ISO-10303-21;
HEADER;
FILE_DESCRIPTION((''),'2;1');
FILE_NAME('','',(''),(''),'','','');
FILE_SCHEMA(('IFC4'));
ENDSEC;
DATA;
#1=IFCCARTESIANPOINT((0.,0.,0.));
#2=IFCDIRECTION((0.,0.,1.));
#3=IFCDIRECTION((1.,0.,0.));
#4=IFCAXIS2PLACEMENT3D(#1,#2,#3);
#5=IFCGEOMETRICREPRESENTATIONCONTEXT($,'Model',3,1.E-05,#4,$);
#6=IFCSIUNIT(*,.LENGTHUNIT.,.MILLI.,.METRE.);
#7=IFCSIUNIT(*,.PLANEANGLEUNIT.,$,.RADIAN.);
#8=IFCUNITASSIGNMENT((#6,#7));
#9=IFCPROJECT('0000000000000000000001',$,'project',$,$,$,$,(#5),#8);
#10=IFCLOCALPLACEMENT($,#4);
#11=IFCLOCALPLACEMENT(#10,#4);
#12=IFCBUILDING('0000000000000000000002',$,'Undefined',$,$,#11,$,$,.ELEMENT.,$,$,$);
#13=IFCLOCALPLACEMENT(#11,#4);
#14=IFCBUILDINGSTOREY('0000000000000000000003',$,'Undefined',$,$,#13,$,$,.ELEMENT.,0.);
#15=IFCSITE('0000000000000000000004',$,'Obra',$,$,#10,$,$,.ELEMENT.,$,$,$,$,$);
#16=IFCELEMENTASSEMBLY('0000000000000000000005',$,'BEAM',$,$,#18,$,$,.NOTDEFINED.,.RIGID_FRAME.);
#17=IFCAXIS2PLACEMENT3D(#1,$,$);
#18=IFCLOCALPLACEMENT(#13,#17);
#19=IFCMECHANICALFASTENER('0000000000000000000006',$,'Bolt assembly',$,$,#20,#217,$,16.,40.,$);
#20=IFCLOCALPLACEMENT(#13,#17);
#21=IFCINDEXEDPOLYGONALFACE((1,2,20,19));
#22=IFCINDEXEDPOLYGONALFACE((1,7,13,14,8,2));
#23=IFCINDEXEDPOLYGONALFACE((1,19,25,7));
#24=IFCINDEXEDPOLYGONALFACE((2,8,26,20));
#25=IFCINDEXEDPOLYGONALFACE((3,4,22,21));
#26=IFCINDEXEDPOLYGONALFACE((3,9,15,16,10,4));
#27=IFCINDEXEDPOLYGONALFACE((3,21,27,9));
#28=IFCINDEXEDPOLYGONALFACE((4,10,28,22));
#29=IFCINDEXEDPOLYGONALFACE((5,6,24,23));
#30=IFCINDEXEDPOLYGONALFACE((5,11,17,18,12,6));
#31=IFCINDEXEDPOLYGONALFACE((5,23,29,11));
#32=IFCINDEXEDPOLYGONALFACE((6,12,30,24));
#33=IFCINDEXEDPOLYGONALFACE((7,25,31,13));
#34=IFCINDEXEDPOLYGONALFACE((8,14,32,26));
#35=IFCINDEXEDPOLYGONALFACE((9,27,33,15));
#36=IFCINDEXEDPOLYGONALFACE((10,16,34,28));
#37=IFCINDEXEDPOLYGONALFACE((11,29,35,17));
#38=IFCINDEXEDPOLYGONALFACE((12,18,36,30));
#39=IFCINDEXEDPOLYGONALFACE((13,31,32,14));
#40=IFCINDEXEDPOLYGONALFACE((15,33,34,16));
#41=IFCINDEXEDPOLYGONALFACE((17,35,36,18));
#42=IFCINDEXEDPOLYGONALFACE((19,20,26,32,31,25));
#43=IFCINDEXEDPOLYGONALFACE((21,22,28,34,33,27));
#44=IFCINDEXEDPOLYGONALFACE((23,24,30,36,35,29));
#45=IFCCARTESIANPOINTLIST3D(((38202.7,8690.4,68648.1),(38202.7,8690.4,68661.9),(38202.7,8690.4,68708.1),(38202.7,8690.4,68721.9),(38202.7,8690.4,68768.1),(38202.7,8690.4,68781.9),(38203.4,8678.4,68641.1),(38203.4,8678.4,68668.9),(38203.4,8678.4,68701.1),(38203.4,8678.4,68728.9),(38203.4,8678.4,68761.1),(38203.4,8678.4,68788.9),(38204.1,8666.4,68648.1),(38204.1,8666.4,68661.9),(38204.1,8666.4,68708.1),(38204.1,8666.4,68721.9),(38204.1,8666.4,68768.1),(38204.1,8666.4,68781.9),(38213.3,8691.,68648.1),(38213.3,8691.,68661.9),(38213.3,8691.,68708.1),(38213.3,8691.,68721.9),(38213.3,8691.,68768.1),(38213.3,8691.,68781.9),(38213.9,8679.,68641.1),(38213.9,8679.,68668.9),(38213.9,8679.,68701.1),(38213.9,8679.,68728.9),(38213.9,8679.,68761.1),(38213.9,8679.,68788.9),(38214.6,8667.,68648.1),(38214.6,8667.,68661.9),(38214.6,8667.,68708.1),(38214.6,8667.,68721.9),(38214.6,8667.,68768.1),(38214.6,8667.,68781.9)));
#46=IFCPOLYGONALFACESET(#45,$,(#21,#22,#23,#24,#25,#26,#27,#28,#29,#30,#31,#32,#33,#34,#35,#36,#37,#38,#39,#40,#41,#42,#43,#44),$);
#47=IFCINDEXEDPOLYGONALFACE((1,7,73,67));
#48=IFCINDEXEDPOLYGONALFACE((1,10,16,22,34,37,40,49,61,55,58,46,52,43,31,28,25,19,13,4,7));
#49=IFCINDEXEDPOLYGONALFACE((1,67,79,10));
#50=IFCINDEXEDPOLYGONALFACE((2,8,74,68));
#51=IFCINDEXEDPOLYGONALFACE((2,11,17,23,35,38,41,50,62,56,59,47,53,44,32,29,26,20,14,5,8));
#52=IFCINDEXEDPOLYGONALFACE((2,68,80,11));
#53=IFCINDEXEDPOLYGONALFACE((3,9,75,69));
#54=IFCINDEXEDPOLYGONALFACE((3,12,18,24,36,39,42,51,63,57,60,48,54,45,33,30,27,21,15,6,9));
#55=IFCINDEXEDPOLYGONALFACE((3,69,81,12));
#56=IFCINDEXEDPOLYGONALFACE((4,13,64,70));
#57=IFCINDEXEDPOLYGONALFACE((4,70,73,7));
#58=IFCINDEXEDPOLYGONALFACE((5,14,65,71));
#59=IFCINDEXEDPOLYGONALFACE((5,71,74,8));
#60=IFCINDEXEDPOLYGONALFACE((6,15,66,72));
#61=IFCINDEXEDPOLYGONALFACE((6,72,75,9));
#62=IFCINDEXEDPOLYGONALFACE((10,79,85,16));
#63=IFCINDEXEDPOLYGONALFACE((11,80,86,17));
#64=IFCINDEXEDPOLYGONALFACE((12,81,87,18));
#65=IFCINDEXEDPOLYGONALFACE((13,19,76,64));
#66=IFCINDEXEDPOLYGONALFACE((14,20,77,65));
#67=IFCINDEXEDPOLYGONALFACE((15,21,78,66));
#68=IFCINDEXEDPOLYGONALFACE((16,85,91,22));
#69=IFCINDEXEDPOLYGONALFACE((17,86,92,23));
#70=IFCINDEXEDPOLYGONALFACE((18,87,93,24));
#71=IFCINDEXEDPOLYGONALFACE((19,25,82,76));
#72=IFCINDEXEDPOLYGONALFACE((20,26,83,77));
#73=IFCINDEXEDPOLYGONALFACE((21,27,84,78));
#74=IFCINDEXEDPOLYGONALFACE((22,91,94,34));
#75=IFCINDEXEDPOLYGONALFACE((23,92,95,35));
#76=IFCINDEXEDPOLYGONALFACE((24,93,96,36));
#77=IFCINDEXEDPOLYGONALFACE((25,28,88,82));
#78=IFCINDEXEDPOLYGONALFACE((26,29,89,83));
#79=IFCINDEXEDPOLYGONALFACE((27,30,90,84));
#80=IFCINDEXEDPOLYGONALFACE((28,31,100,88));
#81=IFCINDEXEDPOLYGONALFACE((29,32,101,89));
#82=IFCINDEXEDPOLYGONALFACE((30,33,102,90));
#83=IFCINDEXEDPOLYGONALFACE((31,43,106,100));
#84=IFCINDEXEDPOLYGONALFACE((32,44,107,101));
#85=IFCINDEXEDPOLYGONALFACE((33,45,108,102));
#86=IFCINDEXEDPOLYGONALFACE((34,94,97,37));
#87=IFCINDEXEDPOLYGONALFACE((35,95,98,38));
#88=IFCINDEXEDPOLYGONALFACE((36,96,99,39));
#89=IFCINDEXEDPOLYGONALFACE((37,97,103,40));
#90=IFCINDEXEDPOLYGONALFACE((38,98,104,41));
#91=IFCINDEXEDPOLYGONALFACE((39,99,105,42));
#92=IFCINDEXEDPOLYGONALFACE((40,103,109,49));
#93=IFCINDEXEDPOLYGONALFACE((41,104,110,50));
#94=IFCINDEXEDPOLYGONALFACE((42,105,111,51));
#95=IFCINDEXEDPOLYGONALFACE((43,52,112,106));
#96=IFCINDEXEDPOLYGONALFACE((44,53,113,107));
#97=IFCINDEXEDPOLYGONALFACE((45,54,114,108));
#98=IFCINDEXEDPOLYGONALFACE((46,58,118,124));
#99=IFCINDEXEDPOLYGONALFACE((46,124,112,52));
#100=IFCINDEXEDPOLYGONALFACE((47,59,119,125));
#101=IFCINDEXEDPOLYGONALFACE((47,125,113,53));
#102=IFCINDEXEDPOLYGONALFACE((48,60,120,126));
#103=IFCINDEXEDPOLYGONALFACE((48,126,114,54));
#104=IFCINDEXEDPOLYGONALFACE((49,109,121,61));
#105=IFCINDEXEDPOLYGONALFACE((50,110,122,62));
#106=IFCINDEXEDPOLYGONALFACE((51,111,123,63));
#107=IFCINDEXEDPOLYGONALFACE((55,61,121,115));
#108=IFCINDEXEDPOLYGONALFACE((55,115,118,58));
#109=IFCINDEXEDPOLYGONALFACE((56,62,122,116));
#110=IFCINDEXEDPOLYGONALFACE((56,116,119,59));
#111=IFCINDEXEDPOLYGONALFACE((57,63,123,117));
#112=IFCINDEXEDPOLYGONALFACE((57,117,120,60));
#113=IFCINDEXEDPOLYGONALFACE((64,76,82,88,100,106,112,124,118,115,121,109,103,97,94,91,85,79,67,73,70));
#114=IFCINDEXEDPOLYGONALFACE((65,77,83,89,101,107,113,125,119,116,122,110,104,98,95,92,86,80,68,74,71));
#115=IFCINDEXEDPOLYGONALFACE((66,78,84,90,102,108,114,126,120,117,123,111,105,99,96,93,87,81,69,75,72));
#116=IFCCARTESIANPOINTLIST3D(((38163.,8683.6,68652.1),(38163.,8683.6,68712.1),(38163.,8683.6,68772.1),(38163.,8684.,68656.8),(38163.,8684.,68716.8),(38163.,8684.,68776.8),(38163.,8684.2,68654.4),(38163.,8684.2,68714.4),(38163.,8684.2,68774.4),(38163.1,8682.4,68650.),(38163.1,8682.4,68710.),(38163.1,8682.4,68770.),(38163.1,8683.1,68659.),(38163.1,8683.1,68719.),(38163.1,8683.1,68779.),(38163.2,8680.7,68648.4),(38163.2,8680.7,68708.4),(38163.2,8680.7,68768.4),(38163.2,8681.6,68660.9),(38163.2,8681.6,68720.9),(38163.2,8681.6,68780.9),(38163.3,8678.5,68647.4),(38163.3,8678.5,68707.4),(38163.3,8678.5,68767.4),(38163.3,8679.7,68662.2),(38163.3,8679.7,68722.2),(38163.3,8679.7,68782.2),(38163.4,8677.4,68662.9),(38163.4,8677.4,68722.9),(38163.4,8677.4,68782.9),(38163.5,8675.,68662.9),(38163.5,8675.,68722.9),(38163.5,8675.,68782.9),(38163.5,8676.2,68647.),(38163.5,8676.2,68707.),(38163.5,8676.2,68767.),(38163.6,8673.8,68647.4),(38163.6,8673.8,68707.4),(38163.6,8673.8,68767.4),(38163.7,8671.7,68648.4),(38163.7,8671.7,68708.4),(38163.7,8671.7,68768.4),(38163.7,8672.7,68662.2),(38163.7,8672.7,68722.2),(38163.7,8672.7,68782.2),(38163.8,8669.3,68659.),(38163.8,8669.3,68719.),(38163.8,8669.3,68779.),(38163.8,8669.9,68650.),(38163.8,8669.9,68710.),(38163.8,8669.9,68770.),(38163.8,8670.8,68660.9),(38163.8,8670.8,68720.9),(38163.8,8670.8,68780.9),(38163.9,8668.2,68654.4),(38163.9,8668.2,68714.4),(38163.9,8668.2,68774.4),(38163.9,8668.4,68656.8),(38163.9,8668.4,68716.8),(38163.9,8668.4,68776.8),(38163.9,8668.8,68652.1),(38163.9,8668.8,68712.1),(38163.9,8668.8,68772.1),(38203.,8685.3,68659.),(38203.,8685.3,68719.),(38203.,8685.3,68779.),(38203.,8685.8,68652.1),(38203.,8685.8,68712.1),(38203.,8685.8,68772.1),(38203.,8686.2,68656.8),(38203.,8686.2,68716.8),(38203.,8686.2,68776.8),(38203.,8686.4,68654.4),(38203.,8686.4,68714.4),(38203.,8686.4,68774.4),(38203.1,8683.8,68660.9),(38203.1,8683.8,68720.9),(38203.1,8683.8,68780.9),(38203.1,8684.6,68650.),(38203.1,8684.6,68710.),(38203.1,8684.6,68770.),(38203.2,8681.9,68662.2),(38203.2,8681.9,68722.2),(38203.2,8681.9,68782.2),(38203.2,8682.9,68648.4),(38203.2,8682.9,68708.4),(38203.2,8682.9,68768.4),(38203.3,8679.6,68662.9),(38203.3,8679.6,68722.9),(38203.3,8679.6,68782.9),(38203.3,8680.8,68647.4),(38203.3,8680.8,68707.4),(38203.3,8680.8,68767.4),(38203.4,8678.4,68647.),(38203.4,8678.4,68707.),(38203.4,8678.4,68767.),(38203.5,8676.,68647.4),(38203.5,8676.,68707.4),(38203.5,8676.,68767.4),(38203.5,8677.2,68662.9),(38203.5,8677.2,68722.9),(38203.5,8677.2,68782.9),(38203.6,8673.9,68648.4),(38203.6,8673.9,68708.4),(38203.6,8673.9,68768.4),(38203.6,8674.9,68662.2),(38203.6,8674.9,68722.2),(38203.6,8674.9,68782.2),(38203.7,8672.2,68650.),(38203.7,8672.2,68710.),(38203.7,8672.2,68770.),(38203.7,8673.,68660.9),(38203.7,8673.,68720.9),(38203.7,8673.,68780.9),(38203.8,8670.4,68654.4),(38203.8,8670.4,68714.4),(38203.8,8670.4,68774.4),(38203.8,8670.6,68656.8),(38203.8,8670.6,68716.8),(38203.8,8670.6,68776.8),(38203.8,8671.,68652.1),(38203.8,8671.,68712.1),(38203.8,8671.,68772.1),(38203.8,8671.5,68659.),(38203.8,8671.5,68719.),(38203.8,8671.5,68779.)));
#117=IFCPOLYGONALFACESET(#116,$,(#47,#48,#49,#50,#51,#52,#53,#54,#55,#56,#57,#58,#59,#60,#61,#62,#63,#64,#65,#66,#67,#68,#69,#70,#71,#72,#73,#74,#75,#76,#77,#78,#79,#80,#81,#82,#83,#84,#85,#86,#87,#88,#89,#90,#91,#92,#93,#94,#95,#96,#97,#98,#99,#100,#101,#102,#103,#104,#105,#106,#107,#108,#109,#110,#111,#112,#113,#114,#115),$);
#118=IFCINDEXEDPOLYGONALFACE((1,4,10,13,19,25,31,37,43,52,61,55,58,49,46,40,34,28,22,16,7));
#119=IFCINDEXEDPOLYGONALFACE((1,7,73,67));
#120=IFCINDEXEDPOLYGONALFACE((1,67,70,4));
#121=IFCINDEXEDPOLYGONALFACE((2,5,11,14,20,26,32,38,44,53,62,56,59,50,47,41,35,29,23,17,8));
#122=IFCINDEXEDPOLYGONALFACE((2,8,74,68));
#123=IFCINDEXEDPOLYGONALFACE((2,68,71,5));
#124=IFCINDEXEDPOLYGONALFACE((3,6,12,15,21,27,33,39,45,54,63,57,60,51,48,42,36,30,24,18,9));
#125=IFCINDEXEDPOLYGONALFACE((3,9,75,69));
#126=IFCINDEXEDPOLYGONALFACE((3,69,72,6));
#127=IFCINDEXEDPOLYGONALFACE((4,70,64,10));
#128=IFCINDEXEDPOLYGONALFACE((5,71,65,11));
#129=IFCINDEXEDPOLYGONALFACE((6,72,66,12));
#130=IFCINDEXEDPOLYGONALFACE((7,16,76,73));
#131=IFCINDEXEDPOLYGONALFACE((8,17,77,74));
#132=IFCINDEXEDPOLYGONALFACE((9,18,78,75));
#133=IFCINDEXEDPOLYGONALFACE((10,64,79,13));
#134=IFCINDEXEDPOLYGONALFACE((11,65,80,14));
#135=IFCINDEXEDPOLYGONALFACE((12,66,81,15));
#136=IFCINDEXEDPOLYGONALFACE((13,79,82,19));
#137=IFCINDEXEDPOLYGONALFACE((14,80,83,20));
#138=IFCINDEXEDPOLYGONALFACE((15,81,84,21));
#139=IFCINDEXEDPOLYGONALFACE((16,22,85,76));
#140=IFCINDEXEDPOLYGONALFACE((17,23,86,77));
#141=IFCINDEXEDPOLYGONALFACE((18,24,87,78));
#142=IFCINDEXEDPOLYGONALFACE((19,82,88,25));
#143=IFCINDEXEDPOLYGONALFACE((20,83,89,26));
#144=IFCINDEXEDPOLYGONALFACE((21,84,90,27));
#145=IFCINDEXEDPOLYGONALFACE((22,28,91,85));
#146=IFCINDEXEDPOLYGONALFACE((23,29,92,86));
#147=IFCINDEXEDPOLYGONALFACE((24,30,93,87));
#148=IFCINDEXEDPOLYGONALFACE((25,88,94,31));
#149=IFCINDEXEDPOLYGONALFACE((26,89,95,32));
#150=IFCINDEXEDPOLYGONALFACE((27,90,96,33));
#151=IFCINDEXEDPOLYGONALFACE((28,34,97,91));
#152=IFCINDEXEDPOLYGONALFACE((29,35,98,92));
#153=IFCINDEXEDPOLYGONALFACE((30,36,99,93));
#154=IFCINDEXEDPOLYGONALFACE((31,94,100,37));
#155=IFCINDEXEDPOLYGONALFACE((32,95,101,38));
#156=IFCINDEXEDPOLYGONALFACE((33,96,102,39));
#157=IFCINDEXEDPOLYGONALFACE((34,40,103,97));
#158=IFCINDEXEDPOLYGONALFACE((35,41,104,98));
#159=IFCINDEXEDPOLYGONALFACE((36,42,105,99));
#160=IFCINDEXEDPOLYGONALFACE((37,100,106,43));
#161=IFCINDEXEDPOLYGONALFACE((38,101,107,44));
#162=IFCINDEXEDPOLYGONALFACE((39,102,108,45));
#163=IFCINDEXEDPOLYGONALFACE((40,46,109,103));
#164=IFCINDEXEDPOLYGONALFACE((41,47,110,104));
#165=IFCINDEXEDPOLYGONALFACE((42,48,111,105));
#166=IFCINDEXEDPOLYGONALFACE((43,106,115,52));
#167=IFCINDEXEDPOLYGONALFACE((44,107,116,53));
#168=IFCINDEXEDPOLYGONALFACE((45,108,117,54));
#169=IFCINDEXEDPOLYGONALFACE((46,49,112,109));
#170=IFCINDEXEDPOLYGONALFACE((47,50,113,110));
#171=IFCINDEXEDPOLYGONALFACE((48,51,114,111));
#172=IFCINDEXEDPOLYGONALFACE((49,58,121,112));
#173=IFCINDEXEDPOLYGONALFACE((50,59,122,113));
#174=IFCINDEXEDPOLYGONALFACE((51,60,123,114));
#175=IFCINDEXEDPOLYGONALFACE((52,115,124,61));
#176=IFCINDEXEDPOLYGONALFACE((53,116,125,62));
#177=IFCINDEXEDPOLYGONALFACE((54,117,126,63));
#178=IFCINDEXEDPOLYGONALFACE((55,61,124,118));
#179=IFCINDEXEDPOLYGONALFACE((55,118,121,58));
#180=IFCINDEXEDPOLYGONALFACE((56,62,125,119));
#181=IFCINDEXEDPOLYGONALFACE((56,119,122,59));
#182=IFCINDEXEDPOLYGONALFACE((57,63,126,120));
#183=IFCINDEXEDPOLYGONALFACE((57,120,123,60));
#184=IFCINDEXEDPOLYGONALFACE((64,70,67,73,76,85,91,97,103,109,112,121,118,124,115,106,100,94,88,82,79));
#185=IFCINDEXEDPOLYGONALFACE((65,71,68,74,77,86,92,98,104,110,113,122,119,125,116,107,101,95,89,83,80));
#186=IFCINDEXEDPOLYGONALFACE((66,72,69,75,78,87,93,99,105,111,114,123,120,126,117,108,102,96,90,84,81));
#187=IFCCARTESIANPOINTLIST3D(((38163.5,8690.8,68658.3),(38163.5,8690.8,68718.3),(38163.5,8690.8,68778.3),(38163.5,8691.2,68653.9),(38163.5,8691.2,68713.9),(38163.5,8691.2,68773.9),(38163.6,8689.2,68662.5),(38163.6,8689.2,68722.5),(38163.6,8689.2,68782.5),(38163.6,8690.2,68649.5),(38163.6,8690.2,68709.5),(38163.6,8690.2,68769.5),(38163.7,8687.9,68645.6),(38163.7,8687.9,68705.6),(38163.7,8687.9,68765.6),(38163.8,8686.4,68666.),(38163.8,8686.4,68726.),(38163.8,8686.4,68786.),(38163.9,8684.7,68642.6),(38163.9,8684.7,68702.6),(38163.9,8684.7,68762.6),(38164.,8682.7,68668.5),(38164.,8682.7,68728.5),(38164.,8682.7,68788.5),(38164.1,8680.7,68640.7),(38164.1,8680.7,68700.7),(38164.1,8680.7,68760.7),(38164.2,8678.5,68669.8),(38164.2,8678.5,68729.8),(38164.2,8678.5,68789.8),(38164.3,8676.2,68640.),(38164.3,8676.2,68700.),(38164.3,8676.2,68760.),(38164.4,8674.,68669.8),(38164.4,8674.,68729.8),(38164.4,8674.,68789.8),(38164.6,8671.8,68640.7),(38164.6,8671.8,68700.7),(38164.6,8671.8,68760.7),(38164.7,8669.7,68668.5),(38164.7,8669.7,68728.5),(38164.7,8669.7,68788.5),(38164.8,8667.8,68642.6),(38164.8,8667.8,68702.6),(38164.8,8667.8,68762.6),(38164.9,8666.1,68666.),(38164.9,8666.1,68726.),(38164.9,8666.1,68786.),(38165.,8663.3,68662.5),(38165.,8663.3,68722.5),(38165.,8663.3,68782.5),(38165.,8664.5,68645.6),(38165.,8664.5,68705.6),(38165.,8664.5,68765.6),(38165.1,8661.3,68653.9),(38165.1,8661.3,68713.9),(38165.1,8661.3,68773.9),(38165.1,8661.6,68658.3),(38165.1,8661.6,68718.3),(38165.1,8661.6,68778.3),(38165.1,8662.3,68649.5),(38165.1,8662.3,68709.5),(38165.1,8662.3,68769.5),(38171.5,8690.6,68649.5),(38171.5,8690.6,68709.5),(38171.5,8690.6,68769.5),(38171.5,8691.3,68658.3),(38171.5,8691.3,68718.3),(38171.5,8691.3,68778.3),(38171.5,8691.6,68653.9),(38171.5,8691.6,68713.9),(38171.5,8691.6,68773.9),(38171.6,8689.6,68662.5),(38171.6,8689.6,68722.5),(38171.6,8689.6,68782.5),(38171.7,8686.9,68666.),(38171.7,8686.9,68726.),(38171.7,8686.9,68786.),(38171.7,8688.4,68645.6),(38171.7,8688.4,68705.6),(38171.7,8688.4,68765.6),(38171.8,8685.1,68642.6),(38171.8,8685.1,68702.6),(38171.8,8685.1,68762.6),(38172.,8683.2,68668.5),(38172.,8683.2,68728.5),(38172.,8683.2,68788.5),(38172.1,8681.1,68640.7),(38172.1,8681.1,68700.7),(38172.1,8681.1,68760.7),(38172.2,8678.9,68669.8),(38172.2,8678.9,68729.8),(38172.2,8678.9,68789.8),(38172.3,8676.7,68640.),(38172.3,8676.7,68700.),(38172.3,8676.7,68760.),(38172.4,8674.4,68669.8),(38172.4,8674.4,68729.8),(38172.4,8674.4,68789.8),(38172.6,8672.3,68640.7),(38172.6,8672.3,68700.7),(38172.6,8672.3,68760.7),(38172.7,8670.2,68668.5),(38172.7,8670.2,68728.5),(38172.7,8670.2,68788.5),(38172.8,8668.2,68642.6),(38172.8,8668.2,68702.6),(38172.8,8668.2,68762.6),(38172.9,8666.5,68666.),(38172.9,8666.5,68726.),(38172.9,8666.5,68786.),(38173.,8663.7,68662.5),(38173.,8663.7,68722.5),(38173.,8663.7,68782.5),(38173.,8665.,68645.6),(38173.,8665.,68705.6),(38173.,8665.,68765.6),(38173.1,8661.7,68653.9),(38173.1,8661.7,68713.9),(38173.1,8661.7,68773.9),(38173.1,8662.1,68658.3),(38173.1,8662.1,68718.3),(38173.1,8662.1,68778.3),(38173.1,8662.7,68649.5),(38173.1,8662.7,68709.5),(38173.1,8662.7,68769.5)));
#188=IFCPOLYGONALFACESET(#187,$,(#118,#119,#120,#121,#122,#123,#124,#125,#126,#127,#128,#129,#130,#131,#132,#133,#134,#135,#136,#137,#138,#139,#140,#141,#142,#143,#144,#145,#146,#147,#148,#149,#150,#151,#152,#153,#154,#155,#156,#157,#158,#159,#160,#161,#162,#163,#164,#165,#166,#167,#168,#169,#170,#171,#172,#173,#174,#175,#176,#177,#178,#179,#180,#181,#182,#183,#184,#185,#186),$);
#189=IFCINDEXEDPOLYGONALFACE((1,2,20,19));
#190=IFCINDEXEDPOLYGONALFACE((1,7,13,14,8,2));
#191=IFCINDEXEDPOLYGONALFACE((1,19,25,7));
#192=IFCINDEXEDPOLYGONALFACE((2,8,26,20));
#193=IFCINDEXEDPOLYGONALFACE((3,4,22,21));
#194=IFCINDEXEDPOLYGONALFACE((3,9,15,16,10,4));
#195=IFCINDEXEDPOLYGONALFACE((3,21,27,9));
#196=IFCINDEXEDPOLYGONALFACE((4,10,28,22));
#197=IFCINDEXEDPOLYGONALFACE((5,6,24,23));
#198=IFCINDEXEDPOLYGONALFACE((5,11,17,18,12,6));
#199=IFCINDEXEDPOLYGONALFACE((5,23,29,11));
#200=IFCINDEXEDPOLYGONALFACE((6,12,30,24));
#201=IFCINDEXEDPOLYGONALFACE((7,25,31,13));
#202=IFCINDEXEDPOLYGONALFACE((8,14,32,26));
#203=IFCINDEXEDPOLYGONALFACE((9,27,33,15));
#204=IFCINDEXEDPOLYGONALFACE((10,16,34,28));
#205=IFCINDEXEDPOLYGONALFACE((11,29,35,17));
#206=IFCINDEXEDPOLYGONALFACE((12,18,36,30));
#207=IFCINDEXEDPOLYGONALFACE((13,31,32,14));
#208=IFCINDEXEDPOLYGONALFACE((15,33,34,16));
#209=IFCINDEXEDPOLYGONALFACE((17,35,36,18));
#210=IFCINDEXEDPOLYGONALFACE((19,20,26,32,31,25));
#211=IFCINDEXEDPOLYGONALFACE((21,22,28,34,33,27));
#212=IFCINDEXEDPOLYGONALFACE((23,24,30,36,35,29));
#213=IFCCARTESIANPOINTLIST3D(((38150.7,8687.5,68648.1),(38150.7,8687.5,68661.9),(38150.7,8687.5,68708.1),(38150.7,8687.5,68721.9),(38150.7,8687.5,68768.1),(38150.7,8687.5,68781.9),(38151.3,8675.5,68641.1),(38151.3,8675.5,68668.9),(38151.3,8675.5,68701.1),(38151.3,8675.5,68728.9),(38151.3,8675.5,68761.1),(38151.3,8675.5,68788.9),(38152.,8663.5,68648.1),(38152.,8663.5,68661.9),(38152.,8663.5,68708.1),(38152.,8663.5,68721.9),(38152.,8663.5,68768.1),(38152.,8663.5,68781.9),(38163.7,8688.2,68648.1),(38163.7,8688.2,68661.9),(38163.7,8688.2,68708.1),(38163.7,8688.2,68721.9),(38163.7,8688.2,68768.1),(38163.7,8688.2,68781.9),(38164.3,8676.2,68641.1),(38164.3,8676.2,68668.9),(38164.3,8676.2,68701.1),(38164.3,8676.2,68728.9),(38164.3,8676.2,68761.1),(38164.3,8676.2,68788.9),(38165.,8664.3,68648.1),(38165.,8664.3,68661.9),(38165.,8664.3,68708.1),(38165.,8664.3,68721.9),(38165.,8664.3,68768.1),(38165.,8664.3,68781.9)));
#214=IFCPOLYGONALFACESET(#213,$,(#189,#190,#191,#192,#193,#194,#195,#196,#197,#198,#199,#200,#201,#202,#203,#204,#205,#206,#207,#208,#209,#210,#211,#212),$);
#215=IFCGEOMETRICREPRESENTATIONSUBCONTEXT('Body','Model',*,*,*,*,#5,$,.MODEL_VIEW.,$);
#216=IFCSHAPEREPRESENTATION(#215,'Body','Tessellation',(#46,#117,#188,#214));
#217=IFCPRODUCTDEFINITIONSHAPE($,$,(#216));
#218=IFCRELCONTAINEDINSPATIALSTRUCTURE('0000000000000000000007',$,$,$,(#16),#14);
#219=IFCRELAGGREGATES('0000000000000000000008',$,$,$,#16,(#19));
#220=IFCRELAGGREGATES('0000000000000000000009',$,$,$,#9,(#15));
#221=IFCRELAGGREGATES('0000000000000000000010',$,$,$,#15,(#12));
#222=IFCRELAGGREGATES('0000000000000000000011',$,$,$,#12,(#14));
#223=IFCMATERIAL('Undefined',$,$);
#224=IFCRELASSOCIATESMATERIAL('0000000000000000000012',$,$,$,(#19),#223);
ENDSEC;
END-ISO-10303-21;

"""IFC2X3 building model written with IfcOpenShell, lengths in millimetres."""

from ifc_helpers import new_model, si_unit, frame, origin_with_axes, origin_2d_with_axis, place, context, subcontext, project, spatial, polyline, circle, outline, extrude, source, transform, mapped, material, element, aggregate, save


model = new_model("IFC2X3")

# Units and contexts
model_context = context("Model", 3, precision=1e-05, world=origin_with_axes())
body_context = subcontext(model_context, "Body", "Model", "MODEL_VIEW")
ifc_project = project(units=[si_unit("LENGTHUNIT", "METRE", prefix="MILLI"), si_unit("PLANEANGLEUNIT", "RADIAN")], contexts=[model_context])

# Site, building, storey
site_placement = place(None, origin_with_axes())
site = spatial("IfcSite", under=ifc_project, at=site_placement, Name="Obra", CompositionType="ELEMENT")
building_placement = place(site_placement, origin_with_axes())
building = spatial("IfcBuilding", under=site, at=building_placement, Name="Undefined", CompositionType="ELEMENT")
storey_placement = place(building_placement, origin_with_axes())
storey = spatial("IfcBuildingStorey", under=building, at=storey_placement, Name="Undefined", CompositionType="ELEMENT", Elevation=0.0)

# Element assembly
assembly_1_placement = place(storey_placement, origin_with_axes())
assembly_1 = element("IfcElementAssembly", 1, at=assembly_1_placement, inside=storey, Name="BEAM", AssemblyPlace="NOTDEFINED", PredefinedType="RIGID_FRAME")

# Mechanical fastener
ifc_material_1 = material(Name="Undefined")
shared_shape_1 = source(origin_with_axes(), body_context, "Body", "SweptSolid", [
    extrude(outline(polyline([(13.9, 0.0), (6.9, 12.0), (-6.9, 12.0), (-13.9, 0.0), (-6.9, -12.0), (6.9, -12.0), (13.9, 0.0)])), frame((0.0, -44.8, 0.0), z_axis=(0.0, 1.0, 0.0), x_axis=(1.0, 0.0, 0.0)), (0.0, 0.0, 1.0), 10.6),
    extrude(circle(Radius=8.0, at=origin_2d_with_axis()), frame((0.0, -34.2, 0.0), z_axis=(0.0, 1.0, 0.0), x_axis=(1.0, 0.0, 0.0)), (0.0, 0.0, 1.0), 40.0),
    extrude(circle(Radius=15.0, at=origin_2d_with_axis()), frame((0.0, -3.1, 0.0), z_axis=(0.0, 1.0, 0.0), x_axis=(1.0, 0.0, 0.0)), (0.0, 0.0, 1.0), 8.0),
    extrude(outline(polyline([(13.9, 0.0), (6.9, 12.0), (-6.9, 12.0), (-13.9, 0.0), (-6.9, -12.0), (6.9, -12.0), (13.9, 0.0)])), frame((0.0, 4.9, 0.0), z_axis=(0.0, 1.0, 0.0), x_axis=(1.0, 0.0, 0.0)), (0.0, 0.0, 1.0), 13.0),
])
mechanical_fastener_1_placement = place(assembly_1_placement, frame((38172.0, 8626.6, 68835.0), z_axis=(-0.055152, 0.998478, 0.0), x_axis=(0.0, 0.0, -1.0)))
mechanical_fastener_1 = element("IfcMechanicalFastener", 2, at=mechanical_fastener_1_placement, material=ifc_material_1, Name="Bolt assembly", NominalDiameter=16.0, NominalLength=40.0, context=body_context, shape_type="MappedRepresentation", body=[
    mapped(shared_shape_1, transform((60.0, 0.0, 50.0))),
    mapped(shared_shape_1, transform((120.0, 0.0, 50.0))),
    mapped(shared_shape_1, transform((180.0, 0.0, 50.0))),
])
aggregate(assembly_1, [mechanical_fastener_1])

save(model, "model.ifc")
